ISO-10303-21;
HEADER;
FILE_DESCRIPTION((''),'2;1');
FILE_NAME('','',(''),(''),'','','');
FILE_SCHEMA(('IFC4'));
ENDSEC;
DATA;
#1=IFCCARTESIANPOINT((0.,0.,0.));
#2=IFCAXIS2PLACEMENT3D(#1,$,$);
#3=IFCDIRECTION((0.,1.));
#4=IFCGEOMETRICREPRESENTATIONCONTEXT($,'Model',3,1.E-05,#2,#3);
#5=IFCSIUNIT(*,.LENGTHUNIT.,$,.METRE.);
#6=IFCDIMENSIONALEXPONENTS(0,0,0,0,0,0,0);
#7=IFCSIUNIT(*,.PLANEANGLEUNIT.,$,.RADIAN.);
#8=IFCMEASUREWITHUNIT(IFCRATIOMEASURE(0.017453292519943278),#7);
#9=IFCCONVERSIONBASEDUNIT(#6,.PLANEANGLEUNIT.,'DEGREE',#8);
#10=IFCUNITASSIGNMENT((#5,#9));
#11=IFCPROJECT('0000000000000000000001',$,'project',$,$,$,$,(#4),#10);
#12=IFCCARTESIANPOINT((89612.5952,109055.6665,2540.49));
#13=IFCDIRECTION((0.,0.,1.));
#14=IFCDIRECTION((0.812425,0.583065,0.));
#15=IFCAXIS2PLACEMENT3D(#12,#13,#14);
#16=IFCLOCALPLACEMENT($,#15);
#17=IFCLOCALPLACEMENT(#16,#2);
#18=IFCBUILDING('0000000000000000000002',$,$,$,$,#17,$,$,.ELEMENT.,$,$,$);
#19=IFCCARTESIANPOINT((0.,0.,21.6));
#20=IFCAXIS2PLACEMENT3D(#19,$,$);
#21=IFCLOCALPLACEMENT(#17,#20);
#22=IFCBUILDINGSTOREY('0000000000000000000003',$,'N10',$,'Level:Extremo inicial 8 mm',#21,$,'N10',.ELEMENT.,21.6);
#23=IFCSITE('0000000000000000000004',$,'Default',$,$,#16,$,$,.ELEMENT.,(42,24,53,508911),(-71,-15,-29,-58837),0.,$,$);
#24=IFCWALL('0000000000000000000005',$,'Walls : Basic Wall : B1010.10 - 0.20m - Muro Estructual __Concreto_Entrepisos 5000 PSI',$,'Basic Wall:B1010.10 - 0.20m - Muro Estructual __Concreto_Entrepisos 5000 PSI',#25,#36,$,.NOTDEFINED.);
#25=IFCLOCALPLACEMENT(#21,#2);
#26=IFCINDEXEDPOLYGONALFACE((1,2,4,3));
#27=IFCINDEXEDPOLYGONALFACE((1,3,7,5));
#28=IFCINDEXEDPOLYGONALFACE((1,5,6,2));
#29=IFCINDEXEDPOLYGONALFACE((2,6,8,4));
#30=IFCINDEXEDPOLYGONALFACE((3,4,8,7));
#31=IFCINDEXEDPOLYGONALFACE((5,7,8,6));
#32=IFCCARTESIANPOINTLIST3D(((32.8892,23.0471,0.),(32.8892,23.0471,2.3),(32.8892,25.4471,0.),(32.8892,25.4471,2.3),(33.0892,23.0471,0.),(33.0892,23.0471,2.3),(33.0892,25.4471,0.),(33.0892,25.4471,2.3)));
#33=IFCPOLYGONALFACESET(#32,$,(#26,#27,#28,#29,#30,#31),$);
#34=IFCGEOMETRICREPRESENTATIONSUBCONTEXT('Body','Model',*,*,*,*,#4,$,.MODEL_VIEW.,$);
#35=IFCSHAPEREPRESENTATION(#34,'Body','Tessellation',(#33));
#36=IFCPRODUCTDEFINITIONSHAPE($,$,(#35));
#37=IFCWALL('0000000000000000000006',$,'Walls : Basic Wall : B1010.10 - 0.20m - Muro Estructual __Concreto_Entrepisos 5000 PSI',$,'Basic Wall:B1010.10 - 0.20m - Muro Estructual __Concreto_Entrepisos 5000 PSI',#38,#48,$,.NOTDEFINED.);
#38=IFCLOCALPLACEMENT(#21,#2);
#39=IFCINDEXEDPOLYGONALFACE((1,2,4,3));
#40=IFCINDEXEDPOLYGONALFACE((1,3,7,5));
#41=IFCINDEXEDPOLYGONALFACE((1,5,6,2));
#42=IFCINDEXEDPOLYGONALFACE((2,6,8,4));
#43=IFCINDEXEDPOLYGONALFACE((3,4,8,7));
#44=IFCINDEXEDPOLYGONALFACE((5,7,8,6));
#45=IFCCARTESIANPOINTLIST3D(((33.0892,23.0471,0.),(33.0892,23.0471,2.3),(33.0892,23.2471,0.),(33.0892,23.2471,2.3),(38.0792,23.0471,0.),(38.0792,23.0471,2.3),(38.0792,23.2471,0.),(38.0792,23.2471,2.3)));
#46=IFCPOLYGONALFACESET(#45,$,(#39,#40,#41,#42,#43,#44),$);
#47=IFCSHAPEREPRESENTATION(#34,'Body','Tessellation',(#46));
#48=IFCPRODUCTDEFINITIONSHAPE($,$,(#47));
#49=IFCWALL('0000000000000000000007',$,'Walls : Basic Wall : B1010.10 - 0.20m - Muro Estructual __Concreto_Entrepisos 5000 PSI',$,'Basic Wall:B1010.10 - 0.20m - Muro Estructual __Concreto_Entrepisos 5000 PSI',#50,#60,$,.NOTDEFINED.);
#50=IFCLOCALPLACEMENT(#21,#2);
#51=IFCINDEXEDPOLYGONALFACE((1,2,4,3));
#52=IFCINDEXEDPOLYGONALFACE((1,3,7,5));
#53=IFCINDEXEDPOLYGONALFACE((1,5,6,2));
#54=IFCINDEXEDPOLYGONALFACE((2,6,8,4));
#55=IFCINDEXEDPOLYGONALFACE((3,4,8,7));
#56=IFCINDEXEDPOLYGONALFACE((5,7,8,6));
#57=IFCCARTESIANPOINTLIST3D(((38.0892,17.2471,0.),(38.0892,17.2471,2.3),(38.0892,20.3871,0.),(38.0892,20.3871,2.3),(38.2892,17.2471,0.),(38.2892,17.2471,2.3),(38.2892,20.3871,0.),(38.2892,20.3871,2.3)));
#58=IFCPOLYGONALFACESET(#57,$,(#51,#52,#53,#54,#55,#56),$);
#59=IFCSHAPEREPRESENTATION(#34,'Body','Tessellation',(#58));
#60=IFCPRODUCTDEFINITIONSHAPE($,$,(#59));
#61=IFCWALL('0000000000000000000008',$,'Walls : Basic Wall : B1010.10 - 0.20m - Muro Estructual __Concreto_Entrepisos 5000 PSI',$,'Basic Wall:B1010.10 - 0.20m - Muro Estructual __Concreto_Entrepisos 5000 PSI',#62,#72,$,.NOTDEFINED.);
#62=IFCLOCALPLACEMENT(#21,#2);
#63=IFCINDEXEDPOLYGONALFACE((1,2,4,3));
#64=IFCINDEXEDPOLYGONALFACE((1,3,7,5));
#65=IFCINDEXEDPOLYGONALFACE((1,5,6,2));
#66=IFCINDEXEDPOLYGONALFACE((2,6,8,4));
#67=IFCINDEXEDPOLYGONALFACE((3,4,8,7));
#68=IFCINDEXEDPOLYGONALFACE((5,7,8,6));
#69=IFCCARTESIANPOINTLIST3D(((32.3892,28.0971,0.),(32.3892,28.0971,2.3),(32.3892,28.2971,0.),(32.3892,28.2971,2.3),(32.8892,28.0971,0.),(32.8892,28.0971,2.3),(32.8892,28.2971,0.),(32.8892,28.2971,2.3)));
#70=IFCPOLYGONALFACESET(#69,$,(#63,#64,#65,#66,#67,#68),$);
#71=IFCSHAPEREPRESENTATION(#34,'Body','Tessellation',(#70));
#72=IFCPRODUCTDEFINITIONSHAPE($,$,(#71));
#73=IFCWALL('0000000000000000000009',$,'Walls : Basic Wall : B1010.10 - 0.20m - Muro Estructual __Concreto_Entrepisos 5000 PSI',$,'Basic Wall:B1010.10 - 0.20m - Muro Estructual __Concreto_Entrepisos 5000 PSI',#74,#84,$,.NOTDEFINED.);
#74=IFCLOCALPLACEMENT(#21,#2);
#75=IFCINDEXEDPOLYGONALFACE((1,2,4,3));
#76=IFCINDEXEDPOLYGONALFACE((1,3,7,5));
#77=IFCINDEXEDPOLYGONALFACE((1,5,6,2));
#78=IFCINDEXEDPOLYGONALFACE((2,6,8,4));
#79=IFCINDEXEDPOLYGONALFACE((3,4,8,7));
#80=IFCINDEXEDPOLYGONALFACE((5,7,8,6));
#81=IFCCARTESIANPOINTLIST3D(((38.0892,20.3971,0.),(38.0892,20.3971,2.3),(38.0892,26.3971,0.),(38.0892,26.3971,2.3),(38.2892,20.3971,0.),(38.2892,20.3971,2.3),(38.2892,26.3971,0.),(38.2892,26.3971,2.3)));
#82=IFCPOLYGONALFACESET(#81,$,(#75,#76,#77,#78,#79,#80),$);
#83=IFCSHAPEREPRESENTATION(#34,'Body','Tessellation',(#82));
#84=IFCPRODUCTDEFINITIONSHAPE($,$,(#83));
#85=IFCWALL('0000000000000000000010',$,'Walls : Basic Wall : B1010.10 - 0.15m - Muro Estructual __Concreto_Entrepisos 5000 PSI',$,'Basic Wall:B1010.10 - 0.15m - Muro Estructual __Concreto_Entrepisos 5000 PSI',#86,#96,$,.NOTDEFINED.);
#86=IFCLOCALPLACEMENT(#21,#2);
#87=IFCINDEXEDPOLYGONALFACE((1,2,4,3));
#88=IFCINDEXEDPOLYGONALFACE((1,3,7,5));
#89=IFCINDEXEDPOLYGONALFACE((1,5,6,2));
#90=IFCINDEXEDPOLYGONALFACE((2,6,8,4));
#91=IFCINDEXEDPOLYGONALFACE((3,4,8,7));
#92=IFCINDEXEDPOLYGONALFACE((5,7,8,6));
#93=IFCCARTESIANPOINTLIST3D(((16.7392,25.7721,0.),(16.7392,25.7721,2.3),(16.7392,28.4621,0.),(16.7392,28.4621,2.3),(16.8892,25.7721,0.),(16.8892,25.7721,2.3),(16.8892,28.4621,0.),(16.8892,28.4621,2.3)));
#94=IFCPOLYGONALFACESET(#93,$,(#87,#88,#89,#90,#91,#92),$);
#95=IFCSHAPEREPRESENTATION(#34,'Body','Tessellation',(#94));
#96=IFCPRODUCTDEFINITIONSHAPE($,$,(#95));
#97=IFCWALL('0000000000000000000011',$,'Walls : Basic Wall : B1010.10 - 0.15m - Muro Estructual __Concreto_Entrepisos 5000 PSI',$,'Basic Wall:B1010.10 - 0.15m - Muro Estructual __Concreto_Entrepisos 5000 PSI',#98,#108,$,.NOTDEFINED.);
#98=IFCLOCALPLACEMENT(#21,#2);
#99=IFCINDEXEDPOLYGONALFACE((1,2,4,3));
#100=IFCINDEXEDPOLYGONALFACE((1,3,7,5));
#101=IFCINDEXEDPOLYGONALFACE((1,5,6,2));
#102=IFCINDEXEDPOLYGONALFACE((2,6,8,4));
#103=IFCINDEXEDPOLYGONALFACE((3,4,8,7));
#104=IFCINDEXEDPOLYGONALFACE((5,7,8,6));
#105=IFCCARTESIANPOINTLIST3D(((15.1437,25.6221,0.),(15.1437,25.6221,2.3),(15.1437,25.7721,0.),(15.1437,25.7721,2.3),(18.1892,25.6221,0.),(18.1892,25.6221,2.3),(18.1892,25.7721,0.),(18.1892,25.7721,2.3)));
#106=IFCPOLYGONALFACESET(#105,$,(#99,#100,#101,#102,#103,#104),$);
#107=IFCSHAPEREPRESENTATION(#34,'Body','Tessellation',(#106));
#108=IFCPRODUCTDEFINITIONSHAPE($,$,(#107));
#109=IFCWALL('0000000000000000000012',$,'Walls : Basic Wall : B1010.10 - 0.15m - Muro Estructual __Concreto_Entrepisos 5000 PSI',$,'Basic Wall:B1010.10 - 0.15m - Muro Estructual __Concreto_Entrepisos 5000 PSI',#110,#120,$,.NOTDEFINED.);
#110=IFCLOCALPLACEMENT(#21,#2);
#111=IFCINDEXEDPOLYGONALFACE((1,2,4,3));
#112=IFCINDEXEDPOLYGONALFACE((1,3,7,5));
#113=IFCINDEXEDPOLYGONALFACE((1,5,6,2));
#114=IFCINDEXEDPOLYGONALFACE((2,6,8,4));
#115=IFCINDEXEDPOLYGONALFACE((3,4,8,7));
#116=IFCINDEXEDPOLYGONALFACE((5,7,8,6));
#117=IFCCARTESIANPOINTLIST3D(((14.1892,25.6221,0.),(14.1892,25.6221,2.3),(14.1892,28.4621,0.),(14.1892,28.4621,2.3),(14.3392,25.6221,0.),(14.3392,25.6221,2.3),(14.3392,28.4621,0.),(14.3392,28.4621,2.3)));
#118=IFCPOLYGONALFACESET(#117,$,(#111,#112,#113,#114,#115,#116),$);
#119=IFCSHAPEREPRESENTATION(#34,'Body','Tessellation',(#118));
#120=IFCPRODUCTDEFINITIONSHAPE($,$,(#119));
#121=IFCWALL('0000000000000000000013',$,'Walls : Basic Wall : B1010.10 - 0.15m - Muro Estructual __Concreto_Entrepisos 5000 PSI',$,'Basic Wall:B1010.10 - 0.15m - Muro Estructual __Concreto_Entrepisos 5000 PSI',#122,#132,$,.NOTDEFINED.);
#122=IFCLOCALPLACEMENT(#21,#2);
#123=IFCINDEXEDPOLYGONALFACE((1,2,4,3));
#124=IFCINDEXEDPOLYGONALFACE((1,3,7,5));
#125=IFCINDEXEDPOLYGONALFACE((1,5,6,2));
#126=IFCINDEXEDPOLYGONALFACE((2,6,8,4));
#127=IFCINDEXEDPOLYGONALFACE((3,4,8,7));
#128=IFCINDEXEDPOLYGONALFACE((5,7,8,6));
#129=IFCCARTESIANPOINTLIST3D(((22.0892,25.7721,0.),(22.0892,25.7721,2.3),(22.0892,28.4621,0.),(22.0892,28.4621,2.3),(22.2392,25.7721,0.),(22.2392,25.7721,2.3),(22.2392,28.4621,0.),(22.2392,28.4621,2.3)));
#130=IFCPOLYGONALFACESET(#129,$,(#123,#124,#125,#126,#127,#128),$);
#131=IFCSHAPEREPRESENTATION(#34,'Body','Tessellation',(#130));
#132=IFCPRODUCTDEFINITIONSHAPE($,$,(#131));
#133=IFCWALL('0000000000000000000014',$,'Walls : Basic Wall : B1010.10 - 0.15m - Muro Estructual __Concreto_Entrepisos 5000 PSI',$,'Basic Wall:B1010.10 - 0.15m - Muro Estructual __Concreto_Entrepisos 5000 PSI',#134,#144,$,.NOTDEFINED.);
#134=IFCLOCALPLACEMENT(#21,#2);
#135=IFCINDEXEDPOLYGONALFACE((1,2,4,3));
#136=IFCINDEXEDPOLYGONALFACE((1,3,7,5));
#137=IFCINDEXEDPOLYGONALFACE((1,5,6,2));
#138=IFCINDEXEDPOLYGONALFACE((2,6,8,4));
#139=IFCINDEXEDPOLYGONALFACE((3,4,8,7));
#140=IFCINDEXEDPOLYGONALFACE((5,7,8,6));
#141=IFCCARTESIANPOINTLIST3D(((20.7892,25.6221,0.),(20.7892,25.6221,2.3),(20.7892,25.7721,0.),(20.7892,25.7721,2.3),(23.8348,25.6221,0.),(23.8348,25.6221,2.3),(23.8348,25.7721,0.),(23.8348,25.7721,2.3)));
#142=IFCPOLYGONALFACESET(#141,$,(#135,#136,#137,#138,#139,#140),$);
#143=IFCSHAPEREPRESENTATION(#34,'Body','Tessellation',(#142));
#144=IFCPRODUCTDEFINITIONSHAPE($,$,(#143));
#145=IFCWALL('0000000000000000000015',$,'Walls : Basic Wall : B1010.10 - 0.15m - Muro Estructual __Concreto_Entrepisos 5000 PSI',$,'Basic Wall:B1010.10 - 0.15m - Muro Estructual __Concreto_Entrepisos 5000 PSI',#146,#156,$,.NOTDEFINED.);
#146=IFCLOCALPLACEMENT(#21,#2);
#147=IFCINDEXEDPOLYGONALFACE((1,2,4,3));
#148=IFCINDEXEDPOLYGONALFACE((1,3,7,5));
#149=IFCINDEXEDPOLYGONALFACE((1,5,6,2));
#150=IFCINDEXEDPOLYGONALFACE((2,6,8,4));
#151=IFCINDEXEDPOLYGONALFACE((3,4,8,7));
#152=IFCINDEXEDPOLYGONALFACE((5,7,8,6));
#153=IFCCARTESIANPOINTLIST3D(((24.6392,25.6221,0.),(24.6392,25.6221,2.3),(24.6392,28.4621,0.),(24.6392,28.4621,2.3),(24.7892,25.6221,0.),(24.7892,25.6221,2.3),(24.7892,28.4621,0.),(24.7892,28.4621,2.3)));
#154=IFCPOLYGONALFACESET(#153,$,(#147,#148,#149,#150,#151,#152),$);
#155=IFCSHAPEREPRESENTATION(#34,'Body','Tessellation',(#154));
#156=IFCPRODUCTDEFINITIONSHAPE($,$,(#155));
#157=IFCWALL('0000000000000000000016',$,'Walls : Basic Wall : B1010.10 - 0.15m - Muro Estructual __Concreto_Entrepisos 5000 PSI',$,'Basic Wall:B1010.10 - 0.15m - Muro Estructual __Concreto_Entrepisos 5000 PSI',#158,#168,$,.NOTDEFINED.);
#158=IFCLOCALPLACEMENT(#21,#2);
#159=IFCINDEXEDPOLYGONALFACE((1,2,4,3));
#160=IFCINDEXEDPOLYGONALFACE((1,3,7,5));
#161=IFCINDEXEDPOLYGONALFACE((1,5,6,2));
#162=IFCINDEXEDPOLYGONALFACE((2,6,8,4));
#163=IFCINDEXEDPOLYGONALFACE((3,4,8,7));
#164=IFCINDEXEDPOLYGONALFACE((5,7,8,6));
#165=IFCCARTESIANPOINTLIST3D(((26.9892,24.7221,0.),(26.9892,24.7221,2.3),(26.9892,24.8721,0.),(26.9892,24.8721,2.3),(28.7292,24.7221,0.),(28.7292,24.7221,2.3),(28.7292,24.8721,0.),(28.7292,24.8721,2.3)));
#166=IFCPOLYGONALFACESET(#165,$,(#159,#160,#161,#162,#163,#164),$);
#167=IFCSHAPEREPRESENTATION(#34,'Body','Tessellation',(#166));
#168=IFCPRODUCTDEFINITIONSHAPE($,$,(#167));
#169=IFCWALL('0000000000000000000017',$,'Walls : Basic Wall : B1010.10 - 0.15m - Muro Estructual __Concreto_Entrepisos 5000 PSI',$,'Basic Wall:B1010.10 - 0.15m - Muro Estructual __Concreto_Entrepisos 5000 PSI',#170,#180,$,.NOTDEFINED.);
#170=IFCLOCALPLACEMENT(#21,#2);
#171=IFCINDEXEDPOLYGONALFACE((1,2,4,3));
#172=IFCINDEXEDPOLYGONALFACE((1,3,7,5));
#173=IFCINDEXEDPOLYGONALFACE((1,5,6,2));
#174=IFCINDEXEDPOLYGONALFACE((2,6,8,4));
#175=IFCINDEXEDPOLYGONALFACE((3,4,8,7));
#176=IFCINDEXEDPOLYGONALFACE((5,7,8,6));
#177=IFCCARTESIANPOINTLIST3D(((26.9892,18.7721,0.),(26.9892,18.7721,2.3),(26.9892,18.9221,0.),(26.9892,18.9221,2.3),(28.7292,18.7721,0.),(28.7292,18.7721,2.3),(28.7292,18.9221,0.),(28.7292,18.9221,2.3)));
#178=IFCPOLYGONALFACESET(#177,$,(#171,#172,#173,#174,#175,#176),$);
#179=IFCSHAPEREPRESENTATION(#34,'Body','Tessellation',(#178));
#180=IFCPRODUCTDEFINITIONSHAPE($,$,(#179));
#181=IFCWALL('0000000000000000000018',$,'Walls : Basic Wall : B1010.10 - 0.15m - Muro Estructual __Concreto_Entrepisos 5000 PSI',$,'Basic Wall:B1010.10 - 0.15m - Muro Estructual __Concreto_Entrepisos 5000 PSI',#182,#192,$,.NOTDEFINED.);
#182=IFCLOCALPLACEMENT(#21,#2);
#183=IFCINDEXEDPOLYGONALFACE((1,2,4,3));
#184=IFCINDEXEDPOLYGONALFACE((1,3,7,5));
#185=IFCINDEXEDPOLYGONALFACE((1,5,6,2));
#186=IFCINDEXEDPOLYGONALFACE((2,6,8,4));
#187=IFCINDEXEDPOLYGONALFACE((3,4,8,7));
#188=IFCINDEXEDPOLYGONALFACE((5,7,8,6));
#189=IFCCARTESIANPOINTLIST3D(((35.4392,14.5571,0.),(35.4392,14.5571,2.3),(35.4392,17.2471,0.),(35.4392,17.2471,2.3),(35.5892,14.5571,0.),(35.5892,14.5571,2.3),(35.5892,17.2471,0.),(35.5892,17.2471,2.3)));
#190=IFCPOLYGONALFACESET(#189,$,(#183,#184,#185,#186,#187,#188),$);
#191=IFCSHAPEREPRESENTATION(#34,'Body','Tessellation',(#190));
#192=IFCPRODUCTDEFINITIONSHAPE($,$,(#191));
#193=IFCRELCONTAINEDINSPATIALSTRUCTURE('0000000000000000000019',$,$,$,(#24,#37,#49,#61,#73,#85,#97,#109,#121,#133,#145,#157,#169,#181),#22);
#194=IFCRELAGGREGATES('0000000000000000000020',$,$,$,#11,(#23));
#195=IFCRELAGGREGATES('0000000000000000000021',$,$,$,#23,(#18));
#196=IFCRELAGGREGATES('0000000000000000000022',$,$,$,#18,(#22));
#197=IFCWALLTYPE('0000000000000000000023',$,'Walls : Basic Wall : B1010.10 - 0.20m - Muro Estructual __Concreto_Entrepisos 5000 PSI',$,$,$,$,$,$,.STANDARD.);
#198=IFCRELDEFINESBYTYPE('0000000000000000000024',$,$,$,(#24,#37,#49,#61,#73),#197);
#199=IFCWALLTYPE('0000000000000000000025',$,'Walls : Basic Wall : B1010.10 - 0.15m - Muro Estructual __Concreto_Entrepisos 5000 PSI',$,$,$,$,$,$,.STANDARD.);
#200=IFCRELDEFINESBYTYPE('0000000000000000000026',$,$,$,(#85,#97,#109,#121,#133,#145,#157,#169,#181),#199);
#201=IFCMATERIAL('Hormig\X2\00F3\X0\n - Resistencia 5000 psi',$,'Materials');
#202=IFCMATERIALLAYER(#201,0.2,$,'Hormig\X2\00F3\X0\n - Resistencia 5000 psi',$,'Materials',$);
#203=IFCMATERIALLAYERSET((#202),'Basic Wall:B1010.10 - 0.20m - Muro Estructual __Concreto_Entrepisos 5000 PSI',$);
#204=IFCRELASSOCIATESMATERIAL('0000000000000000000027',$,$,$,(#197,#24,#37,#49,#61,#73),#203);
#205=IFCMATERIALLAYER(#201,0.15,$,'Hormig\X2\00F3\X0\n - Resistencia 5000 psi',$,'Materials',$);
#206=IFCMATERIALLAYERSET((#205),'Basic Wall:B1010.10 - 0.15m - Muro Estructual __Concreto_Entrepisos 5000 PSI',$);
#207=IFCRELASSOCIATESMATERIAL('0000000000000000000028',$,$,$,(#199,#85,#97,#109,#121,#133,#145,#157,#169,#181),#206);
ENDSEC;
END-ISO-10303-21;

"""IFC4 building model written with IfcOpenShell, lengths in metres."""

from ifc_helpers import new_model, entity, si_unit, converted_unit, direction, frame, frame_2d, origin, place, context, subcontext, project, spatial, rectangle, extrude, material, layer, layer_set, layer_usage, type_object, element, save


model = new_model("IFC4")

# Units and contexts
model_context = context("Model", 3, precision=1e-05, world=origin(), true_north=direction((0.0, 1.0)))
body_context = subcontext(model_context, "Body", "Model", "MODEL_VIEW")
ifc_project = project(units=[si_unit("LENGTHUNIT", "METRE"), converted_unit("PLANEANGLEUNIT", "DEGREE", entity("IfcRatioMeasure", 0.017453292519943278), si_unit("PLANEANGLEUNIT", "RADIAN"), dimensions=[0, 0, 0, 0, 0, 0, 0])], contexts=[model_context])

# Site, building, storey
site_placement = place(None, frame((89612.5952, 109055.6665, 2540.49), z_axis=(0.0, 0.0, 1.0), x_axis=(0.812425, 0.583065, 0.0)))
site = spatial("IfcSite", under=ifc_project, at=site_placement, Name="Default", CompositionType="ELEMENT", RefLatitude=(42, 24, 53, 508911), RefLongitude=(-71, -15, -29, -58837), RefElevation=0.0)
building_placement = place(site_placement, origin())
building = spatial("IfcBuilding", under=site, at=building_placement, CompositionType="ELEMENT")
storey_placement = place(building_placement, frame((0.0, 0.0, 21.6)))
storey = spatial("IfcBuildingStorey", under=building, at=storey_placement, Name="N10", ObjectType="Level:Extremo inicial 8 mm", LongName="N10", CompositionType="ELEMENT", Elevation=21.6)

# Walls
ifc_material = material(Name="Hormigón - Resistencia 5000 psi", Category="Materials")
ifc_layer_1 = layer(ifc_material, 0.2, Name="Hormigón - Resistencia 5000 psi", Category="Materials")
ifc_layer_set_1 = layer_set([ifc_layer_1], Name="Basic Wall:B1010.10 - 0.20m - Muro Estructual __Concreto_Entrepisos 5000 PSI")
wall_type_1 = type_object("IfcWallType", Name="Walls : Basic Wall : B1010.10 - 0.20m - Muro Estructual __Concreto_Entrepisos 5000 PSI", PredefinedType="STANDARD", material=ifc_layer_set_1)
ifc_layer_usage_1 = layer_usage(ifc_layer_set_1, "AXIS2", "POSITIVE", -0.1)
wall_1_placement = place(storey_placement, frame((32.9892, 25.4471, 0.0), z_axis=(0.0, 0.0, 1.0), x_axis=(0.0, -1.0, 0.0)))
element("IfcWall", 1, at=wall_1_placement, inside=storey, type_object=wall_type_1, material=ifc_layer_usage_1, Name="Walls : Basic Wall : B1010.10 - 0.20m - Muro Estructual __Concreto_Entrepisos 5000 PSI", ObjectType="Basic Wall:B1010.10 - 0.20m - Muro Estructual __Concreto_Entrepisos 5000 PSI", PredefinedType="NOTDEFINED", context=body_context, shape_type="SweptSolid", body=[
    extrude(rectangle(XDim=2.4, YDim=0.2, at=frame_2d((1.2, 0.0), x_axis=(-1.0, 0.0))), origin(), (0.0, 0.0, 1.0), 2.3),
])
ifc_layer_usage_2 = layer_usage(ifc_layer_set_1, "AXIS2", "POSITIVE", -0.1)
wall_2_placement = place(storey_placement, frame((33.0892, 23.1471, 0.0)))
element("IfcWall", 2, at=wall_2_placement, inside=storey, type_object=wall_type_1, material=ifc_layer_usage_2, Name="Walls : Basic Wall : B1010.10 - 0.20m - Muro Estructual __Concreto_Entrepisos 5000 PSI", ObjectType="Basic Wall:B1010.10 - 0.20m - Muro Estructual __Concreto_Entrepisos 5000 PSI", PredefinedType="NOTDEFINED", context=body_context, shape_type="SweptSolid", body=[
    extrude(rectangle(XDim=4.99, YDim=0.2, at=frame_2d((2.495, 0.0), x_axis=(-1.0, 0.0))), origin(), (0.0, 0.0, 1.0), 2.3),
])
ifc_layer_usage_3 = layer_usage(ifc_layer_set_1, "AXIS2", "POSITIVE", -0.1)
wall_3_placement = place(storey_placement, frame((38.1892, 17.2471, 0.0), z_axis=(0.0, 0.0, 1.0), x_axis=(0.0, 1.0, 0.0)))
element("IfcWall", 3, at=wall_3_placement, inside=storey, type_object=wall_type_1, material=ifc_layer_usage_3, Name="Walls : Basic Wall : B1010.10 - 0.20m - Muro Estructual __Concreto_Entrepisos 5000 PSI", ObjectType="Basic Wall:B1010.10 - 0.20m - Muro Estructual __Concreto_Entrepisos 5000 PSI", PredefinedType="NOTDEFINED", context=body_context, shape_type="SweptSolid", body=[
    extrude(rectangle(XDim=3.14, YDim=0.2, at=frame_2d((1.57, 0.0), x_axis=(-1.0, 0.0))), origin(), (0.0, 0.0, 1.0), 2.3),
])
ifc_layer_usage_4 = layer_usage(ifc_layer_set_1, "AXIS2", "POSITIVE", -0.1)
wall_4_placement = place(storey_placement, frame((32.3892, 28.1971, 0.0)))
element("IfcWall", 4, at=wall_4_placement, inside=storey, type_object=wall_type_1, material=ifc_layer_usage_4, Name="Walls : Basic Wall : B1010.10 - 0.20m - Muro Estructual __Concreto_Entrepisos 5000 PSI", ObjectType="Basic Wall:B1010.10 - 0.20m - Muro Estructual __Concreto_Entrepisos 5000 PSI", PredefinedType="NOTDEFINED", context=body_context, shape_type="SweptSolid", body=[
    extrude(rectangle(XDim=0.5, YDim=0.2, at=frame_2d((0.25, 0.0), x_axis=(-1.0, 0.0))), origin(), (0.0, 0.0, 1.0), 2.3),
])
ifc_layer_usage_5 = layer_usage(ifc_layer_set_1, "AXIS2", "POSITIVE", -0.1)
wall_5_placement = place(storey_placement, frame((38.1892, 20.3971, 0.0), z_axis=(0.0, 0.0, 1.0), x_axis=(0.0, 1.0, 0.0)))
element("IfcWall", 5, at=wall_5_placement, inside=storey, type_object=wall_type_1, material=ifc_layer_usage_5, Name="Walls : Basic Wall : B1010.10 - 0.20m - Muro Estructual __Concreto_Entrepisos 5000 PSI", ObjectType="Basic Wall:B1010.10 - 0.20m - Muro Estructual __Concreto_Entrepisos 5000 PSI", PredefinedType="NOTDEFINED", context=body_context, shape_type="SweptSolid", body=[
    extrude(rectangle(XDim=6.0, YDim=0.2, at=frame_2d((3.0, 0.0), x_axis=(-1.0, 0.0))), origin(), (0.0, 0.0, 1.0), 2.3),
])
ifc_layer_2 = layer(ifc_material, 0.15, Name="Hormigón - Resistencia 5000 psi", Category="Materials")
ifc_layer_set_2 = layer_set([ifc_layer_2], Name="Basic Wall:B1010.10 - 0.15m - Muro Estructual __Concreto_Entrepisos 5000 PSI")
ifc_layer_usage_6 = layer_usage(ifc_layer_set_2, "AXIS2", "POSITIVE", -0.075)
wall_type_2 = type_object("IfcWallType", Name="Walls : Basic Wall : B1010.10 - 0.15m - Muro Estructual __Concreto_Entrepisos 5000 PSI", PredefinedType="STANDARD", material=ifc_layer_set_2)
wall_6_placement = place(storey_placement, frame((16.8142, 28.4621, 0.0), z_axis=(0.0, 0.0, 1.0), x_axis=(0.0, -1.0, 0.0)))
element("IfcWall", 6, at=wall_6_placement, inside=storey, type_object=wall_type_2, material=ifc_layer_usage_6, Name="Walls : Basic Wall : B1010.10 - 0.15m - Muro Estructual __Concreto_Entrepisos 5000 PSI", ObjectType="Basic Wall:B1010.10 - 0.15m - Muro Estructual __Concreto_Entrepisos 5000 PSI", PredefinedType="NOTDEFINED", context=body_context, shape_type="SweptSolid", body=[
    extrude(rectangle(XDim=2.69, YDim=0.15, at=frame_2d((1.345, 0.0), x_axis=(-1.0, 0.0))), origin(), (0.0, 0.0, 1.0), 2.3),
])
ifc_layer_usage_7 = layer_usage(ifc_layer_set_2, "AXIS2", "POSITIVE", -0.075)
wall_7_placement = place(storey_placement, frame((18.1892, 25.6971, 0.0), z_axis=(0.0, 0.0, 1.0), x_axis=(-1.0, 0.0, 0.0)))
element("IfcWall", 7, at=wall_7_placement, inside=storey, type_object=wall_type_2, material=ifc_layer_usage_7, Name="Walls : Basic Wall : B1010.10 - 0.15m - Muro Estructual __Concreto_Entrepisos 5000 PSI", ObjectType="Basic Wall:B1010.10 - 0.15m - Muro Estructual __Concreto_Entrepisos 5000 PSI", PredefinedType="NOTDEFINED", context=body_context, shape_type="SweptSolid", body=[
    extrude(rectangle(XDim=3.0455, YDim=0.15, at=frame_2d((1.5228, 0.0), x_axis=(-1.0, 0.0))), origin(), (0.0, 0.0, 1.0), 2.3),
])
ifc_layer_usage_8 = layer_usage(ifc_layer_set_2, "AXIS2", "POSITIVE", -0.075)
wall_8_placement = place(storey_placement, frame((14.2642, 28.4621, 0.0), z_axis=(0.0, 0.0, 1.0), x_axis=(0.0, -1.0, 0.0)))
element("IfcWall", 8, at=wall_8_placement, inside=storey, type_object=wall_type_2, material=ifc_layer_usage_8, Name="Walls : Basic Wall : B1010.10 - 0.15m - Muro Estructual __Concreto_Entrepisos 5000 PSI", ObjectType="Basic Wall:B1010.10 - 0.15m - Muro Estructual __Concreto_Entrepisos 5000 PSI", PredefinedType="NOTDEFINED", context=body_context, shape_type="SweptSolid", body=[
    extrude(rectangle(XDim=2.84, YDim=0.15, at=frame_2d((1.42, 0.0), x_axis=(-1.0, 0.0))), origin(), (0.0, 0.0, 1.0), 2.3),
])
ifc_layer_usage_9 = layer_usage(ifc_layer_set_2, "AXIS2", "NEGATIVE", 0.075)
wall_9_placement = place(storey_placement, frame((22.1642, 28.4621, 0.0), z_axis=(0.0, 0.0, 1.0), x_axis=(0.0, -1.0, 0.0)))
element("IfcWall", 9, at=wall_9_placement, inside=storey, type_object=wall_type_2, material=ifc_layer_usage_9, Name="Walls : Basic Wall : B1010.10 - 0.15m - Muro Estructual __Concreto_Entrepisos 5000 PSI", ObjectType="Basic Wall:B1010.10 - 0.15m - Muro Estructual __Concreto_Entrepisos 5000 PSI", PredefinedType="NOTDEFINED", context=body_context, shape_type="SweptSolid", body=[
    extrude(rectangle(XDim=2.69, YDim=0.15, at=frame_2d((1.345, 0.0), x_axis=(-1.0, 0.0))), origin(), (0.0, 0.0, 1.0), 2.3),
])
ifc_layer_usage_10 = layer_usage(ifc_layer_set_2, "AXIS2", "NEGATIVE", 0.075)
wall_10_placement = place(storey_placement, frame((20.7892, 25.6971, 0.0)))
element("IfcWall", 10, at=wall_10_placement, inside=storey, type_object=wall_type_2, material=ifc_layer_usage_10, Name="Walls : Basic Wall : B1010.10 - 0.15m - Muro Estructual __Concreto_Entrepisos 5000 PSI", ObjectType="Basic Wall:B1010.10 - 0.15m - Muro Estructual __Concreto_Entrepisos 5000 PSI", PredefinedType="NOTDEFINED", context=body_context, shape_type="SweptSolid", body=[
    extrude(rectangle(XDim=3.0455, YDim=0.15, at=frame_2d((1.5228, 0.0), x_axis=(-1.0, 0.0))), origin(), (0.0, 0.0, 1.0), 2.3),
])
ifc_layer_usage_11 = layer_usage(ifc_layer_set_2, "AXIS2", "NEGATIVE", 0.075)
wall_11_placement = place(storey_placement, frame((24.7142, 28.4621, 0.0), z_axis=(0.0, 0.0, 1.0), x_axis=(0.0, -1.0, 0.0)))
element("IfcWall", 11, at=wall_11_placement, inside=storey, type_object=wall_type_2, material=ifc_layer_usage_11, Name="Walls : Basic Wall : B1010.10 - 0.15m - Muro Estructual __Concreto_Entrepisos 5000 PSI", ObjectType="Basic Wall:B1010.10 - 0.15m - Muro Estructual __Concreto_Entrepisos 5000 PSI", PredefinedType="NOTDEFINED", context=body_context, shape_type="SweptSolid", body=[
    extrude(rectangle(XDim=2.84, YDim=0.15, at=frame_2d((1.42, 0.0), x_axis=(-1.0, 0.0))), origin(), (0.0, 0.0, 1.0), 2.3),
])
ifc_layer_usage_12 = layer_usage(ifc_layer_set_2, "AXIS2", "NEGATIVE", 0.075)
wall_12_placement = place(storey_placement, frame((26.9892, 24.7971, 0.0)))
element("IfcWall", 12, at=wall_12_placement, inside=storey, type_object=wall_type_2, material=ifc_layer_usage_12, Name="Walls : Basic Wall : B1010.10 - 0.15m - Muro Estructual __Concreto_Entrepisos 5000 PSI", ObjectType="Basic Wall:B1010.10 - 0.15m - Muro Estructual __Concreto_Entrepisos 5000 PSI", PredefinedType="NOTDEFINED", context=body_context, shape_type="SweptSolid", body=[
    extrude(rectangle(XDim=1.74, YDim=0.15, at=frame_2d((0.87, 0.0), x_axis=(-1.0, 0.0))), origin(), (0.0, 0.0, 1.0), 2.3),
])
ifc_layer_usage_13 = layer_usage(ifc_layer_set_2, "AXIS2", "POSITIVE", -0.075)
wall_13_placement = place(storey_placement, frame((26.9892, 18.8471, 0.0)))
element("IfcWall", 13, at=wall_13_placement, inside=storey, type_object=wall_type_2, material=ifc_layer_usage_13, Name="Walls : Basic Wall : B1010.10 - 0.15m - Muro Estructual __Concreto_Entrepisos 5000 PSI", ObjectType="Basic Wall:B1010.10 - 0.15m - Muro Estructual __Concreto_Entrepisos 5000 PSI", PredefinedType="NOTDEFINED", context=body_context, shape_type="SweptSolid", body=[
    extrude(rectangle(XDim=1.74, YDim=0.15, at=frame_2d((0.87, 0.0), x_axis=(-1.0, 0.0))), origin(), (0.0, 0.0, 1.0), 2.3),
])
ifc_layer_usage_14 = layer_usage(ifc_layer_set_2, "AXIS2", "NEGATIVE", 0.075)
wall_14_placement = place(storey_placement, frame((35.5142, 14.5571, 0.0), z_axis=(0.0, 0.0, 1.0), x_axis=(0.0, 1.0, 0.0)))
element("IfcWall", 14, at=wall_14_placement, inside=storey, type_object=wall_type_2, material=ifc_layer_usage_14, Name="Walls : Basic Wall : B1010.10 - 0.15m - Muro Estructual __Concreto_Entrepisos 5000 PSI", ObjectType="Basic Wall:B1010.10 - 0.15m - Muro Estructual __Concreto_Entrepisos 5000 PSI", PredefinedType="NOTDEFINED", context=body_context, shape_type="SweptSolid", body=[
    extrude(rectangle(XDim=2.69, YDim=0.15, at=frame_2d((1.345, 0.0), x_axis=(-1.0, 0.0))), origin(), (0.0, 0.0, 1.0), 2.3),
])

save(model, "model.ifc")
